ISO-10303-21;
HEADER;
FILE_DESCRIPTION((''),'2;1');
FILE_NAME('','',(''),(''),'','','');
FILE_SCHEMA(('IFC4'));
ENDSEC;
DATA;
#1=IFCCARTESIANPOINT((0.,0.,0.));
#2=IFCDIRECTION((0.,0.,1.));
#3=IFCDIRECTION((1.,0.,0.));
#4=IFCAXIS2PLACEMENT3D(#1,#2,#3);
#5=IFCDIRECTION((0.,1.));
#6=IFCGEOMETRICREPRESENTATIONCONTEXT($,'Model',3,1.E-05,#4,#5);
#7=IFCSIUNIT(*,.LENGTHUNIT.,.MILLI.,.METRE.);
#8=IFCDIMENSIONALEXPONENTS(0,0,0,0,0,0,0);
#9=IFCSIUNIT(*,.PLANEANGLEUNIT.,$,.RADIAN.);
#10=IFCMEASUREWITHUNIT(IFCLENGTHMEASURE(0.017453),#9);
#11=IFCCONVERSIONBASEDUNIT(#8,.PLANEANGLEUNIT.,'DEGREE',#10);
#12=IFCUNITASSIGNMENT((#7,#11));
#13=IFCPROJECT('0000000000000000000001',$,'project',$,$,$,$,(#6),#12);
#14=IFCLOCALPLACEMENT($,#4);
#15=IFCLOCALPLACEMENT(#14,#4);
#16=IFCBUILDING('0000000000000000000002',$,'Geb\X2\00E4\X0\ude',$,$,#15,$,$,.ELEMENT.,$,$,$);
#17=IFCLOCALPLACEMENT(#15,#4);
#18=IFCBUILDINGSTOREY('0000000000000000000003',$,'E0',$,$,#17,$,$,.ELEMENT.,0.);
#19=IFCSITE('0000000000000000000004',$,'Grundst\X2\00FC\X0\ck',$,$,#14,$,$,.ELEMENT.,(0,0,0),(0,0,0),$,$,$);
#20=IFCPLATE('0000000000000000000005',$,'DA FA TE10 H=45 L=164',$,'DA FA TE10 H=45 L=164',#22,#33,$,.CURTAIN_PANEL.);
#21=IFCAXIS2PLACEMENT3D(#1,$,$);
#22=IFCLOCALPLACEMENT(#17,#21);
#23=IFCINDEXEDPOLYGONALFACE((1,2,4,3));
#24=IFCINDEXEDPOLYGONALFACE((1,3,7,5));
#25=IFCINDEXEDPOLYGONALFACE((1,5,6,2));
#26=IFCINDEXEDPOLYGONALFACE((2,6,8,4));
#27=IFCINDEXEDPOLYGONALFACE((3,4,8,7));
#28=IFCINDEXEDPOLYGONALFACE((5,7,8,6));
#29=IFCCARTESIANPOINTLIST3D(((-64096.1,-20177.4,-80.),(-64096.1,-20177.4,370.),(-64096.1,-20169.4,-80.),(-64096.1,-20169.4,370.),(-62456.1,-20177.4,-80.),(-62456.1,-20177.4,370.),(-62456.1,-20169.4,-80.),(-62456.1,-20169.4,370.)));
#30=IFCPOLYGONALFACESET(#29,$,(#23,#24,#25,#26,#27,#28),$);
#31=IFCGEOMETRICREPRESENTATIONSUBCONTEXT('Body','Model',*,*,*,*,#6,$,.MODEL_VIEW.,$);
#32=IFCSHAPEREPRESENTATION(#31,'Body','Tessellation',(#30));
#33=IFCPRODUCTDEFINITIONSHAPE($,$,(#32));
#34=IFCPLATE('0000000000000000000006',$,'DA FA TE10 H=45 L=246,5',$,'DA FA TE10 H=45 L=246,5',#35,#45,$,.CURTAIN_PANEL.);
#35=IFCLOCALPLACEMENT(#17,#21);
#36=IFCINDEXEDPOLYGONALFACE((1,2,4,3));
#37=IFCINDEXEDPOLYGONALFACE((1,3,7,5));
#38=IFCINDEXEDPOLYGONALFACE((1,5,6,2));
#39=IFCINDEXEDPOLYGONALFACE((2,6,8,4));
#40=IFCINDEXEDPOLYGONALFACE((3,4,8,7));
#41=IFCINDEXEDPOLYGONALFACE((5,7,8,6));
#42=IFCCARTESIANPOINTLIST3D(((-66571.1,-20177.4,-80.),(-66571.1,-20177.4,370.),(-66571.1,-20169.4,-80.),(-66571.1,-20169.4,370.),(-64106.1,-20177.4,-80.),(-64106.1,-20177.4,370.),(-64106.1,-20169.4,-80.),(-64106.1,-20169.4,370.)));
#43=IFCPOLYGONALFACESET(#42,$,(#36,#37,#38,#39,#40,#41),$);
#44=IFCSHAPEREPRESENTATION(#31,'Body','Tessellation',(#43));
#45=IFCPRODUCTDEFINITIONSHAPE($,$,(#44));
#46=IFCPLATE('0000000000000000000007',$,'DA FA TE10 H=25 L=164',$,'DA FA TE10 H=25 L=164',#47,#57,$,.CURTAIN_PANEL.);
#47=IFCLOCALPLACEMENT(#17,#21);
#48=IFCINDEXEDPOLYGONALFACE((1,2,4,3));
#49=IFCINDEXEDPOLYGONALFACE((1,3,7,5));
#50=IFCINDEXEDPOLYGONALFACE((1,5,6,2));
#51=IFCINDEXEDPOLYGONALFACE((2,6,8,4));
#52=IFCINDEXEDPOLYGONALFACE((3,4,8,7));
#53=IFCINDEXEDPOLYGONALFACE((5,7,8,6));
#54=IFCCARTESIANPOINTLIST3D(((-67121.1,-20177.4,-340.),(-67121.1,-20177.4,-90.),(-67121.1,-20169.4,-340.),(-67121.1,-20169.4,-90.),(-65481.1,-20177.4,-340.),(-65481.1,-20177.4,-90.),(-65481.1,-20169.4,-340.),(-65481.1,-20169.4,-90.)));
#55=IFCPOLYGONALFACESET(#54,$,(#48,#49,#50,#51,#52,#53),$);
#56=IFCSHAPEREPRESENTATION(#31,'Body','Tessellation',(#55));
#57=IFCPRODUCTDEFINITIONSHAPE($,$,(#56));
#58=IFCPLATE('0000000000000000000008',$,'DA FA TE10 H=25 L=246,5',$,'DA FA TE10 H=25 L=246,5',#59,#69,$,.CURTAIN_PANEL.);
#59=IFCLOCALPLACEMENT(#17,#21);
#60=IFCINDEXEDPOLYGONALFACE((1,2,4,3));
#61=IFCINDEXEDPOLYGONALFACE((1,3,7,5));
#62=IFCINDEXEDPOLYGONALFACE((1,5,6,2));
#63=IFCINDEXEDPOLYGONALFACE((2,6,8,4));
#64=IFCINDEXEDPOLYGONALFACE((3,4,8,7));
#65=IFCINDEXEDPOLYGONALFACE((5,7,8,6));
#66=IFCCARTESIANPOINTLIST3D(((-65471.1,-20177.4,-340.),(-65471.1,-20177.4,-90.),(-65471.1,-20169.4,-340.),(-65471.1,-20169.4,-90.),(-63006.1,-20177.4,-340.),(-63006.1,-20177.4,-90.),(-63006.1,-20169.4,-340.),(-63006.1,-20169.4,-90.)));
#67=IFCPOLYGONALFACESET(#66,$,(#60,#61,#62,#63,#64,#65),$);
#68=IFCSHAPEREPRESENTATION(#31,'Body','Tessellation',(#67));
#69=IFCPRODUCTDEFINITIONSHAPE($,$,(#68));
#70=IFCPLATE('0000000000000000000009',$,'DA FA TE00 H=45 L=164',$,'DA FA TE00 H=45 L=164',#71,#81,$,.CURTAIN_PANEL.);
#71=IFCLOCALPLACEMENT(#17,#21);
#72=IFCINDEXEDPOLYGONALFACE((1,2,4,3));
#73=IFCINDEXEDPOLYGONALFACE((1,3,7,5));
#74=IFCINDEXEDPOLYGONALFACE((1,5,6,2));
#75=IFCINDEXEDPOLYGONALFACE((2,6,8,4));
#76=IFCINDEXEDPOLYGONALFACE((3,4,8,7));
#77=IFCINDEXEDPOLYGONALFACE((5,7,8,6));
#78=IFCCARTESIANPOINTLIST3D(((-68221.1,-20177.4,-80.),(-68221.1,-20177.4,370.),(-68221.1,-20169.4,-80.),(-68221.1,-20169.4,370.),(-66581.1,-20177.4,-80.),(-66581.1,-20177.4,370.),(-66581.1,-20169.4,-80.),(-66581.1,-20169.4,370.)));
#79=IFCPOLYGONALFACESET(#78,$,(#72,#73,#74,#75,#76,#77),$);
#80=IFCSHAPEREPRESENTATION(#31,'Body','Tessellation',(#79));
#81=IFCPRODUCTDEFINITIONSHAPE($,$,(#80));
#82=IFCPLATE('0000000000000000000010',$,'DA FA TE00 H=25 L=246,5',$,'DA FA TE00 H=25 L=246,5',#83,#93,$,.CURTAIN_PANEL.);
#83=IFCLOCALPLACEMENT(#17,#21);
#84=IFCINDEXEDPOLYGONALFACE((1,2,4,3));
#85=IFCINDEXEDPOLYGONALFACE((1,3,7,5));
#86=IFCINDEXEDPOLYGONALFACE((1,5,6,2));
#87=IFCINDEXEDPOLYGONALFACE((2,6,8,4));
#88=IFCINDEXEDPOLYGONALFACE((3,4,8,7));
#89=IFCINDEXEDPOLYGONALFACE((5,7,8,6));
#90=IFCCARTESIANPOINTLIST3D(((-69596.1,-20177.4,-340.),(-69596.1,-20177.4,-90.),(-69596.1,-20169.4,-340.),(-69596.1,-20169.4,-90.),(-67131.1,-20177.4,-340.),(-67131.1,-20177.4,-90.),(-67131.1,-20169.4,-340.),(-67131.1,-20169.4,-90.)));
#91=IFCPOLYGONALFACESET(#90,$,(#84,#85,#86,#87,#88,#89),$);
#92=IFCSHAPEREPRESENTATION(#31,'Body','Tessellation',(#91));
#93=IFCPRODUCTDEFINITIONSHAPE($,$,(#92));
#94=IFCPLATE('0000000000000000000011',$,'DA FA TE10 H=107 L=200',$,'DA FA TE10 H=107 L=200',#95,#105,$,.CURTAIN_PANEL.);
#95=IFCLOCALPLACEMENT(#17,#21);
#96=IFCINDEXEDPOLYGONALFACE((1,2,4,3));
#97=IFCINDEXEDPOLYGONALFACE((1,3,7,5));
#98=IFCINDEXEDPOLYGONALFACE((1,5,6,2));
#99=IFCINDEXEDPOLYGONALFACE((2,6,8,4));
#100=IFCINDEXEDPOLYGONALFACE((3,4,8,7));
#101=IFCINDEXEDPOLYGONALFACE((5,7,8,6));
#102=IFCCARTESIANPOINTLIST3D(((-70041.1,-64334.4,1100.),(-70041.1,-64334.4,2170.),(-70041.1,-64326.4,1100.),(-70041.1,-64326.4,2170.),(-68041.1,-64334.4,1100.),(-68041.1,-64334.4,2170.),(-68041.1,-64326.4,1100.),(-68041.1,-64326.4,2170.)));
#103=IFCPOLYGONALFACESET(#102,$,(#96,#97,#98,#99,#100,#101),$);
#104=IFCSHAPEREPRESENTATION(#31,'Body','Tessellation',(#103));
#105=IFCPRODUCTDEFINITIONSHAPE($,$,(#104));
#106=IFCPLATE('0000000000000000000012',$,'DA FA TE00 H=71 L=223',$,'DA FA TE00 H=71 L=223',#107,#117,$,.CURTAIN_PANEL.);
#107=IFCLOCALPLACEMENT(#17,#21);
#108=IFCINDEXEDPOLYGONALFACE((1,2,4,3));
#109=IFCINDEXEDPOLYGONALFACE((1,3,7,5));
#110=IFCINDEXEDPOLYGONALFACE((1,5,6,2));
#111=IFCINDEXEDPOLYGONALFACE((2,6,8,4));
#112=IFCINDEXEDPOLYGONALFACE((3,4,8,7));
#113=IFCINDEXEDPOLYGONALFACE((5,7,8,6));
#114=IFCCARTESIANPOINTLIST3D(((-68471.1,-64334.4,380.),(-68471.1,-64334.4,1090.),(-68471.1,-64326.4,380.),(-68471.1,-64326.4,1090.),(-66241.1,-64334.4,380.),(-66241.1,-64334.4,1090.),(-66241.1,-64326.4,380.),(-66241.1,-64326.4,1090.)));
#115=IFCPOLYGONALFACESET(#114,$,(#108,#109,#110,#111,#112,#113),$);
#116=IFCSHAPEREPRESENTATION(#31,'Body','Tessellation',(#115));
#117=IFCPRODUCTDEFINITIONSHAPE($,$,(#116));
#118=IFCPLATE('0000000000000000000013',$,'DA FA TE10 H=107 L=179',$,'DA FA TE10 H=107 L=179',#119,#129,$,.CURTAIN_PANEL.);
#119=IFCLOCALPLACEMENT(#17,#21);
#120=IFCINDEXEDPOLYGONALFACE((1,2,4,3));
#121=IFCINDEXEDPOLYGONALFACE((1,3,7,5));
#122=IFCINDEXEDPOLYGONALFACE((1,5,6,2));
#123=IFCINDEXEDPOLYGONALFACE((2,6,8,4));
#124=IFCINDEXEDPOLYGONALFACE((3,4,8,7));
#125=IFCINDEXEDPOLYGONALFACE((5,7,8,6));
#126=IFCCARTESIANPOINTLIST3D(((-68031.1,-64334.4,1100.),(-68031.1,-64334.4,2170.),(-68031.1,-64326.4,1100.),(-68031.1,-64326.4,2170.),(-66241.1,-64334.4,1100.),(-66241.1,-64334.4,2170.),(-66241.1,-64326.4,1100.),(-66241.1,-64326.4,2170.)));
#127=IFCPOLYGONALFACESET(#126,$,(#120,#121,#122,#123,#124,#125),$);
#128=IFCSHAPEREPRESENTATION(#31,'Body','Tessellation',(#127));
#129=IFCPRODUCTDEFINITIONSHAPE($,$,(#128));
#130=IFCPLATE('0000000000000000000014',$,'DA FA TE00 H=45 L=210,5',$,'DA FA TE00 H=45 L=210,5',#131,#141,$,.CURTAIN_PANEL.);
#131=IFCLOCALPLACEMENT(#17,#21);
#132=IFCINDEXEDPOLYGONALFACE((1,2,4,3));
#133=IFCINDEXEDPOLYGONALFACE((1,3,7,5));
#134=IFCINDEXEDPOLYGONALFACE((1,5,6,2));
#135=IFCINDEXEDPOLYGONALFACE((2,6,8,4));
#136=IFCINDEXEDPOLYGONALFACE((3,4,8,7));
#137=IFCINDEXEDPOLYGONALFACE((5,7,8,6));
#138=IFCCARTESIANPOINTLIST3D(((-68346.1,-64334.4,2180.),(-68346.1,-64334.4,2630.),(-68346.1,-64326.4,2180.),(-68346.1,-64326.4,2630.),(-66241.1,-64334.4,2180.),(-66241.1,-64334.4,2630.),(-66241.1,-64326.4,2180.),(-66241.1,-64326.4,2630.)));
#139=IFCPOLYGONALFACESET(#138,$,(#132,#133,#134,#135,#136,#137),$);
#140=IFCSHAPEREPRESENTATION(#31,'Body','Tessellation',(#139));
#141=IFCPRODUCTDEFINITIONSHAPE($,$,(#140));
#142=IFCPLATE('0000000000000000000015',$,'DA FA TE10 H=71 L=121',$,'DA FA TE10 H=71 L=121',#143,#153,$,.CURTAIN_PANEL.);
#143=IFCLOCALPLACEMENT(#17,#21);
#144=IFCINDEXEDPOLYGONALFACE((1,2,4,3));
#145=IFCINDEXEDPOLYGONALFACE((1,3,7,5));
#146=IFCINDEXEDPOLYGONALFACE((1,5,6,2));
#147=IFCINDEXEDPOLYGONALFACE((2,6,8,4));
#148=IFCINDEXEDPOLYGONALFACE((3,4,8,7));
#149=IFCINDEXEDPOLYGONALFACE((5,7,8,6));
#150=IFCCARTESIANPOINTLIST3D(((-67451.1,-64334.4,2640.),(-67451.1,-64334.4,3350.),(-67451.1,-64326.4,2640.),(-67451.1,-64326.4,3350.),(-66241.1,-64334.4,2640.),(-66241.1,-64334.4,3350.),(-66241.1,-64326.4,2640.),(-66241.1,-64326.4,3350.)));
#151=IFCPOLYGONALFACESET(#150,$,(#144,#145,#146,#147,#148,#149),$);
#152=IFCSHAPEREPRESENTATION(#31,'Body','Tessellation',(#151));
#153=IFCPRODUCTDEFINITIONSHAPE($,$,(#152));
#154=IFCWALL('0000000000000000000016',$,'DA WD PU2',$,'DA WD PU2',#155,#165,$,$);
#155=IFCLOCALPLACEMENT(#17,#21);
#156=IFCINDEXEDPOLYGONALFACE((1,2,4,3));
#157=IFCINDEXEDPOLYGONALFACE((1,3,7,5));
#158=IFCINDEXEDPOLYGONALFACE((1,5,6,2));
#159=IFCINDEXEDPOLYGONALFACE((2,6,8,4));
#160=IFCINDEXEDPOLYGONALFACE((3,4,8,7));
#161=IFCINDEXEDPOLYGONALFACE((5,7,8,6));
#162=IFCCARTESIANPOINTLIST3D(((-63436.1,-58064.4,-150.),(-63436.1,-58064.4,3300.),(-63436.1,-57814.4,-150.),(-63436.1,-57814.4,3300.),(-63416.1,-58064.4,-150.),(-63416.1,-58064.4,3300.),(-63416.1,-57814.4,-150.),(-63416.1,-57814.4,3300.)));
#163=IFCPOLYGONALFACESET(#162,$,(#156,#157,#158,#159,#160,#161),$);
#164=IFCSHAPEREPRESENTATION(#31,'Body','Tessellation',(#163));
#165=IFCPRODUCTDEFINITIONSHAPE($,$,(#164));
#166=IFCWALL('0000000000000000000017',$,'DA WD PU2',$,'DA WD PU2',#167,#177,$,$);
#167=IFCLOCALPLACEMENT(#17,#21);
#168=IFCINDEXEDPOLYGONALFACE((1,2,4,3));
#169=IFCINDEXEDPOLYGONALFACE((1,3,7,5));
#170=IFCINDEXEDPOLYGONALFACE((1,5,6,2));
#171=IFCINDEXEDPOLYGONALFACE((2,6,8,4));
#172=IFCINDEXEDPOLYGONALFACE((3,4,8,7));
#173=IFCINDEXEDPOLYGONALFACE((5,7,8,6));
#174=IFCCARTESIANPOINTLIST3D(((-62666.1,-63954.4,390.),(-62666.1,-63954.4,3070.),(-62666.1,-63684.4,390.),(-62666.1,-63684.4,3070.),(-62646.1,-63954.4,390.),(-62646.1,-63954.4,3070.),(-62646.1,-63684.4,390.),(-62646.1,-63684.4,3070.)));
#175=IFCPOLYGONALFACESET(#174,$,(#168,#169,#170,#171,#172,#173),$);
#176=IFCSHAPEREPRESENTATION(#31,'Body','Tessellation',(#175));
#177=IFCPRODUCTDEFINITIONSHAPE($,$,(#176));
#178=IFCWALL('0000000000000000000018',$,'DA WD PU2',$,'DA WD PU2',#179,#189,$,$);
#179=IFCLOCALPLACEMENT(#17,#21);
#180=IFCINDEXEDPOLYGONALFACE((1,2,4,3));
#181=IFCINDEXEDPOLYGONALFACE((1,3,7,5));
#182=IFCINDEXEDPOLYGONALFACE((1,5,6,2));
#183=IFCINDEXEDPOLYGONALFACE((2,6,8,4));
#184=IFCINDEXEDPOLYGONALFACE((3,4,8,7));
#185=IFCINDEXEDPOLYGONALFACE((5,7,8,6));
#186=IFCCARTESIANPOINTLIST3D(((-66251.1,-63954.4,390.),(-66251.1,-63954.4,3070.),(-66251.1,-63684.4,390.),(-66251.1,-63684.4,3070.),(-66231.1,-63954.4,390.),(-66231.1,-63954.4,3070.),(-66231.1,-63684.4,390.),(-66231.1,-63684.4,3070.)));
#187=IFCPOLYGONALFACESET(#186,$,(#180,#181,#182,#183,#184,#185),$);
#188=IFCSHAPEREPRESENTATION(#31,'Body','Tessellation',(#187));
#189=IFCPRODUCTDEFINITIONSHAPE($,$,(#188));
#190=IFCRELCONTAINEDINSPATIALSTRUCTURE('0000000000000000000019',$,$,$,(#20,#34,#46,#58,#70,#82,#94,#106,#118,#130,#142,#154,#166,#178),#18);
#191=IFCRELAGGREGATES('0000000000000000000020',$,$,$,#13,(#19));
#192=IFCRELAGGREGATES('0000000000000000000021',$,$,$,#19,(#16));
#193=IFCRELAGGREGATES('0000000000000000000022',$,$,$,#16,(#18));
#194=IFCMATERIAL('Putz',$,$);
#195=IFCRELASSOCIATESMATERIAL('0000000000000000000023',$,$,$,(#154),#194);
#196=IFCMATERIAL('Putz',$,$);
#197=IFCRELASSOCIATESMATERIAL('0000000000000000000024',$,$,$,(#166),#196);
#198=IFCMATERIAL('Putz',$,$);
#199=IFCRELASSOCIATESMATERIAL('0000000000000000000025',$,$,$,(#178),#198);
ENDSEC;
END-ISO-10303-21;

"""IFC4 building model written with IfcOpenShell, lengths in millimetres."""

from ifc_helpers import new_model, entity, si_unit, converted_unit, direction, frame, origin_with_axes, place, context, subcontext, project, spatial, line, indexed_curve, outline, extrude, material, element, save


model = new_model("IFC4")

# Units and contexts
model_context = context("Model", 3, precision=1e-05, world=origin_with_axes(), true_north=direction((0.0, 1.0)))
body_context = subcontext(model_context, "Body", "Model", "MODEL_VIEW")
ifc_project = project(units=[si_unit("LENGTHUNIT", "METRE", prefix="MILLI"), converted_unit("PLANEANGLEUNIT", "DEGREE", entity("IfcLengthMeasure", 0.017453), si_unit("PLANEANGLEUNIT", "RADIAN"), dimensions=[0, 0, 0, 0, 0, 0, 0])], contexts=[model_context])

# Site, building, storey
site_placement = place(None, origin_with_axes())
site = spatial("IfcSite", under=ifc_project, at=site_placement, Name="Grundstück", CompositionType="ELEMENT", RefLatitude=(0, 0, 0), RefLongitude=(0, 0, 0))
building_placement = place(site_placement, origin_with_axes())
building = spatial("IfcBuilding", under=site, at=building_placement, Name="Gebäude", CompositionType="ELEMENT")
storey_placement = place(building_placement, origin_with_axes())
storey = spatial("IfcBuildingStorey", under=building, at=storey_placement, Name="E0", CompositionType="ELEMENT", Elevation=0.0)

# Plates
plate_1_placement = place(storey_placement, frame((-63276.1, -20169.4, -80.0), z_axis=(0.0, 0.0, 1.0), x_axis=(-1.0, 0.0, 0.0)))
element("IfcPlate", 1, at=plate_1_placement, inside=storey, Name="DA FA TE10 H=45 L=164", ObjectType="DA FA TE10 H=45 L=164", PredefinedType="CURTAIN_PANEL", context=body_context, shape_type="SweptSolid", body=[
    extrude(outline(indexed_curve([(-820.0, 0.0), (820.0, 0.0), (820.0, 8.0), (-820.0, 8.0)], segments=[line(1, 2), line(2, 3), line(3, 4), line(4, 1)])), frame((0.0, 0.0, 450.0), z_axis=(0.0, 0.0, 1.0), x_axis=(1.0, 0.0, 0.0)), (0.0, 0.0, -1.0), 450.0),
])
plate_2_placement = place(storey_placement, frame((-65338.6, -20169.4, -80.0), z_axis=(0.0, 0.0, 1.0), x_axis=(-1.0, 0.0, 0.0)))
element("IfcPlate", 2, at=plate_2_placement, inside=storey, Name="DA FA TE10 H=45 L=246,5", ObjectType="DA FA TE10 H=45 L=246,5", PredefinedType="CURTAIN_PANEL", context=body_context, shape_type="SweptSolid", body=[
    extrude(outline(indexed_curve([(-1232.5, 0.0), (1232.5, 0.0), (1232.5, 8.0), (-1232.5, 8.0)], segments=[line(1, 2), line(2, 3), line(3, 4), line(4, 1)])), frame((0.0, 0.0, 450.0), z_axis=(0.0, 0.0, 1.0), x_axis=(1.0, 0.0, 0.0)), (0.0, 0.0, -1.0), 450.0),
])
plate_3_placement = place(storey_placement, frame((-66301.1, -20169.4, -340.0), z_axis=(0.0, 0.0, 1.0), x_axis=(-1.0, 0.0, 0.0)))
element("IfcPlate", 3, at=plate_3_placement, inside=storey, Name="DA FA TE10 H=25 L=164", ObjectType="DA FA TE10 H=25 L=164", PredefinedType="CURTAIN_PANEL", context=body_context, shape_type="SweptSolid", body=[
    extrude(outline(indexed_curve([(-820.0, 0.0), (820.0, 0.0), (820.0, 8.0), (-820.0, 8.0)], segments=[line(1, 2), line(2, 3), line(3, 4), line(4, 1)])), frame((0.0, 0.0, 250.0), z_axis=(0.0, 0.0, 1.0), x_axis=(1.0, 0.0, 0.0)), (0.0, 0.0, -1.0), 250.0),
])
plate_4_placement = place(storey_placement, frame((-64238.6, -20169.4, -340.0), z_axis=(0.0, 0.0, 1.0), x_axis=(-1.0, 0.0, 0.0)))
element("IfcPlate", 4, at=plate_4_placement, inside=storey, Name="DA FA TE10 H=25 L=246,5", ObjectType="DA FA TE10 H=25 L=246,5", PredefinedType="CURTAIN_PANEL", context=body_context, shape_type="SweptSolid", body=[
    extrude(outline(indexed_curve([(-1232.5, 0.0), (1232.5, 0.0), (1232.5, 8.0), (-1232.5, 8.0)], segments=[line(1, 2), line(2, 3), line(3, 4), line(4, 1)])), frame((0.0, 0.0, 250.0), z_axis=(0.0, 0.0, 1.0), x_axis=(1.0, 0.0, 0.0)), (0.0, 0.0, -1.0), 250.0),
])
plate_5_placement = place(storey_placement, frame((-67401.1, -20169.4, -80.0), z_axis=(0.0, 0.0, 1.0), x_axis=(-1.0, 0.0, 0.0)))
element("IfcPlate", 5, at=plate_5_placement, inside=storey, Name="DA FA TE00 H=45 L=164", ObjectType="DA FA TE00 H=45 L=164", PredefinedType="CURTAIN_PANEL", context=body_context, shape_type="SweptSolid", body=[
    extrude(outline(indexed_curve([(-820.0, 0.0), (820.0, 0.0), (820.0, 8.0), (-820.0, 8.0)], segments=[line(1, 2), line(2, 3), line(3, 4), line(4, 1)])), frame((0.0, 0.0, 450.0), z_axis=(0.0, 0.0, 1.0), x_axis=(1.0, 0.0, 0.0)), (0.0, 0.0, -1.0), 450.0),
])
plate_6_placement = place(storey_placement, frame((-68363.6, -20169.4, -340.0), z_axis=(0.0, 0.0, 1.0), x_axis=(-1.0, 0.0, 0.0)))
element("IfcPlate", 6, at=plate_6_placement, inside=storey, Name="DA FA TE00 H=25 L=246,5", ObjectType="DA FA TE00 H=25 L=246,5", PredefinedType="CURTAIN_PANEL", context=body_context, shape_type="SweptSolid", body=[
    extrude(outline(indexed_curve([(-1232.5, 0.0), (1232.5, 0.0), (1232.5, 8.0), (-1232.5, 8.0)], segments=[line(1, 2), line(2, 3), line(3, 4), line(4, 1)])), frame((0.0, 0.0, 250.0), z_axis=(0.0, 0.0, 1.0), x_axis=(1.0, 0.0, 0.0)), (0.0, 0.0, -1.0), 250.0),
])
plate_7_placement = place(storey_placement, frame((-69041.1, -64334.4, 1100.0), z_axis=(0.0, 0.0, 1.0), x_axis=(1.0, 0.0, 0.0)))
element("IfcPlate", 7, at=plate_7_placement, inside=storey, Name="DA FA TE10 H=107 L=200", ObjectType="DA FA TE10 H=107 L=200", PredefinedType="CURTAIN_PANEL", context=body_context, shape_type="SweptSolid", body=[
    extrude(outline(indexed_curve([(-1000.0, 0.0), (1000.0, 0.0), (1000.0, 8.0), (-1000.0, 8.0)], segments=[line(1, 2), line(2, 3), line(3, 4), line(4, 1)])), frame((0.0, 0.0, 1070.0), z_axis=(0.0, 0.0, 1.0), x_axis=(1.0, 0.0, 0.0)), (0.0, 0.0, -1.0), 1070.0),
])
plate_8_placement = place(storey_placement, frame((-67356.1, -64334.4, 380.0), z_axis=(0.0, 0.0, 1.0), x_axis=(1.0, 0.0, 0.0)))
element("IfcPlate", 8, at=plate_8_placement, inside=storey, Name="DA FA TE00 H=71 L=223", ObjectType="DA FA TE00 H=71 L=223", PredefinedType="CURTAIN_PANEL", context=body_context, shape_type="SweptSolid", body=[
    extrude(outline(indexed_curve([(-1115.0, 0.0), (1115.0, 0.0), (1115.0, 8.0), (-1115.0, 8.0)], segments=[line(1, 2), line(2, 3), line(3, 4), line(4, 1)])), frame((0.0, 0.0, 710.0), z_axis=(0.0, 0.0, 1.0), x_axis=(1.0, 0.0, 0.0)), (0.0, 0.0, -1.0), 710.0),
])
plate_9_placement = place(storey_placement, frame((-67136.1, -64334.4, 1100.0), z_axis=(0.0, 0.0, 1.0), x_axis=(1.0, 0.0, 0.0)))
element("IfcPlate", 9, at=plate_9_placement, inside=storey, Name="DA FA TE10 H=107 L=179", ObjectType="DA FA TE10 H=107 L=179", PredefinedType="CURTAIN_PANEL", context=body_context, shape_type="SweptSolid", body=[
    extrude(outline(indexed_curve([(-895.0, 0.0), (895.0, 0.0), (895.0, 8.0), (-895.0, 8.0)], segments=[line(1, 2), line(2, 3), line(3, 4), line(4, 1)])), frame((0.0, 0.0, 1070.0), z_axis=(0.0, 0.0, 1.0), x_axis=(1.0, 0.0, 0.0)), (0.0, 0.0, -1.0), 1070.0),
])
plate_10_placement = place(storey_placement, frame((-67293.6, -64334.4, 2180.0), z_axis=(0.0, 0.0, 1.0), x_axis=(1.0, 0.0, 0.0)))
element("IfcPlate", 10, at=plate_10_placement, inside=storey, Name="DA FA TE00 H=45 L=210,5", ObjectType="DA FA TE00 H=45 L=210,5", PredefinedType="CURTAIN_PANEL", context=body_context, shape_type="SweptSolid", body=[
    extrude(outline(indexed_curve([(-1052.5, 0.0), (1052.5, 0.0), (1052.5, 8.0), (-1052.5, 8.0)], segments=[line(1, 2), line(2, 3), line(3, 4), line(4, 1)])), frame((0.0, 0.0, 450.0), z_axis=(0.0, 0.0, 1.0), x_axis=(1.0, 0.0, 0.0)), (0.0, 0.0, -1.0), 450.0),
])
plate_11_placement = place(storey_placement, frame((-66846.1, -64334.4, 2640.0), z_axis=(0.0, 0.0, 1.0), x_axis=(1.0, 0.0, 0.0)))
element("IfcPlate", 11, at=plate_11_placement, inside=storey, Name="DA FA TE10 H=71 L=121", ObjectType="DA FA TE10 H=71 L=121", PredefinedType="CURTAIN_PANEL", context=body_context, shape_type="SweptSolid", body=[
    extrude(outline(indexed_curve([(-605.0, 0.0), (605.0, 0.0), (605.0, 8.0), (-605.0, 8.0)], segments=[line(1, 2), line(2, 3), line(3, 4), line(4, 1)])), frame((0.0, 0.0, 710.0), z_axis=(0.0, 0.0, 1.0), x_axis=(1.0, 0.0, 0.0)), (0.0, 0.0, -1.0), 710.0),
])

# Walls
ifc_material_1 = material(Name="Putz")
wall_1_placement = place(storey_placement, frame((-63426.1, -58064.4, -150.0), z_axis=(0.0, 0.0, 1.0), x_axis=(0.0, 1.0, 0.0)))
element("IfcWall", 12, at=wall_1_placement, inside=storey, material=ifc_material_1, Name="DA WD PU2", ObjectType="DA WD PU2", context=body_context, shape_type="SweptSolid", body=[
    extrude(outline(indexed_curve([(0.0, -10.0), (0.0, 10.0), (250.0, 10.0), (250.0, -10.0)], segments=[line(1, 2), line(2, 3), line(3, 4), line(4, 1)])), origin_with_axes(), (0.0, 0.0, 1.0), 3450.0),
])
ifc_material_2 = material(Name="Putz")
wall_2_placement = place(storey_placement, frame((-62656.1, -63684.4, 390.0), z_axis=(0.0, 0.0, 1.0), x_axis=(0.0, -1.0, 0.0)))
element("IfcWall", 13, at=wall_2_placement, inside=storey, material=ifc_material_2, Name="DA WD PU2", ObjectType="DA WD PU2", context=body_context, shape_type="SweptSolid", body=[
    extrude(outline(indexed_curve([(0.0, -10.0), (0.0, 10.0), (270.0, 10.0), (270.0, -10.0)], segments=[line(1, 2), line(2, 3), line(3, 4), line(4, 1)])), origin_with_axes(), (0.0, 0.0, 1.0), 2680.0),
])
ifc_material_3 = material(Name="Putz")
wall_3_placement = place(storey_placement, frame((-66241.1, -63684.4, 390.0), z_axis=(0.0, 0.0, 1.0), x_axis=(0.0, -1.0, 0.0)))
element("IfcWall", 14, at=wall_3_placement, inside=storey, material=ifc_material_3, Name="DA WD PU2", ObjectType="DA WD PU2", context=body_context, shape_type="SweptSolid", body=[
    extrude(outline(indexed_curve([(0.0, -10.0), (0.0, 10.0), (270.0, 10.0), (270.0, -10.0)], segments=[line(1, 2), line(2, 3), line(3, 4), line(4, 1)])), origin_with_axes(), (0.0, 0.0, 1.0), 2680.0),
])

save(model, "model.ifc")
